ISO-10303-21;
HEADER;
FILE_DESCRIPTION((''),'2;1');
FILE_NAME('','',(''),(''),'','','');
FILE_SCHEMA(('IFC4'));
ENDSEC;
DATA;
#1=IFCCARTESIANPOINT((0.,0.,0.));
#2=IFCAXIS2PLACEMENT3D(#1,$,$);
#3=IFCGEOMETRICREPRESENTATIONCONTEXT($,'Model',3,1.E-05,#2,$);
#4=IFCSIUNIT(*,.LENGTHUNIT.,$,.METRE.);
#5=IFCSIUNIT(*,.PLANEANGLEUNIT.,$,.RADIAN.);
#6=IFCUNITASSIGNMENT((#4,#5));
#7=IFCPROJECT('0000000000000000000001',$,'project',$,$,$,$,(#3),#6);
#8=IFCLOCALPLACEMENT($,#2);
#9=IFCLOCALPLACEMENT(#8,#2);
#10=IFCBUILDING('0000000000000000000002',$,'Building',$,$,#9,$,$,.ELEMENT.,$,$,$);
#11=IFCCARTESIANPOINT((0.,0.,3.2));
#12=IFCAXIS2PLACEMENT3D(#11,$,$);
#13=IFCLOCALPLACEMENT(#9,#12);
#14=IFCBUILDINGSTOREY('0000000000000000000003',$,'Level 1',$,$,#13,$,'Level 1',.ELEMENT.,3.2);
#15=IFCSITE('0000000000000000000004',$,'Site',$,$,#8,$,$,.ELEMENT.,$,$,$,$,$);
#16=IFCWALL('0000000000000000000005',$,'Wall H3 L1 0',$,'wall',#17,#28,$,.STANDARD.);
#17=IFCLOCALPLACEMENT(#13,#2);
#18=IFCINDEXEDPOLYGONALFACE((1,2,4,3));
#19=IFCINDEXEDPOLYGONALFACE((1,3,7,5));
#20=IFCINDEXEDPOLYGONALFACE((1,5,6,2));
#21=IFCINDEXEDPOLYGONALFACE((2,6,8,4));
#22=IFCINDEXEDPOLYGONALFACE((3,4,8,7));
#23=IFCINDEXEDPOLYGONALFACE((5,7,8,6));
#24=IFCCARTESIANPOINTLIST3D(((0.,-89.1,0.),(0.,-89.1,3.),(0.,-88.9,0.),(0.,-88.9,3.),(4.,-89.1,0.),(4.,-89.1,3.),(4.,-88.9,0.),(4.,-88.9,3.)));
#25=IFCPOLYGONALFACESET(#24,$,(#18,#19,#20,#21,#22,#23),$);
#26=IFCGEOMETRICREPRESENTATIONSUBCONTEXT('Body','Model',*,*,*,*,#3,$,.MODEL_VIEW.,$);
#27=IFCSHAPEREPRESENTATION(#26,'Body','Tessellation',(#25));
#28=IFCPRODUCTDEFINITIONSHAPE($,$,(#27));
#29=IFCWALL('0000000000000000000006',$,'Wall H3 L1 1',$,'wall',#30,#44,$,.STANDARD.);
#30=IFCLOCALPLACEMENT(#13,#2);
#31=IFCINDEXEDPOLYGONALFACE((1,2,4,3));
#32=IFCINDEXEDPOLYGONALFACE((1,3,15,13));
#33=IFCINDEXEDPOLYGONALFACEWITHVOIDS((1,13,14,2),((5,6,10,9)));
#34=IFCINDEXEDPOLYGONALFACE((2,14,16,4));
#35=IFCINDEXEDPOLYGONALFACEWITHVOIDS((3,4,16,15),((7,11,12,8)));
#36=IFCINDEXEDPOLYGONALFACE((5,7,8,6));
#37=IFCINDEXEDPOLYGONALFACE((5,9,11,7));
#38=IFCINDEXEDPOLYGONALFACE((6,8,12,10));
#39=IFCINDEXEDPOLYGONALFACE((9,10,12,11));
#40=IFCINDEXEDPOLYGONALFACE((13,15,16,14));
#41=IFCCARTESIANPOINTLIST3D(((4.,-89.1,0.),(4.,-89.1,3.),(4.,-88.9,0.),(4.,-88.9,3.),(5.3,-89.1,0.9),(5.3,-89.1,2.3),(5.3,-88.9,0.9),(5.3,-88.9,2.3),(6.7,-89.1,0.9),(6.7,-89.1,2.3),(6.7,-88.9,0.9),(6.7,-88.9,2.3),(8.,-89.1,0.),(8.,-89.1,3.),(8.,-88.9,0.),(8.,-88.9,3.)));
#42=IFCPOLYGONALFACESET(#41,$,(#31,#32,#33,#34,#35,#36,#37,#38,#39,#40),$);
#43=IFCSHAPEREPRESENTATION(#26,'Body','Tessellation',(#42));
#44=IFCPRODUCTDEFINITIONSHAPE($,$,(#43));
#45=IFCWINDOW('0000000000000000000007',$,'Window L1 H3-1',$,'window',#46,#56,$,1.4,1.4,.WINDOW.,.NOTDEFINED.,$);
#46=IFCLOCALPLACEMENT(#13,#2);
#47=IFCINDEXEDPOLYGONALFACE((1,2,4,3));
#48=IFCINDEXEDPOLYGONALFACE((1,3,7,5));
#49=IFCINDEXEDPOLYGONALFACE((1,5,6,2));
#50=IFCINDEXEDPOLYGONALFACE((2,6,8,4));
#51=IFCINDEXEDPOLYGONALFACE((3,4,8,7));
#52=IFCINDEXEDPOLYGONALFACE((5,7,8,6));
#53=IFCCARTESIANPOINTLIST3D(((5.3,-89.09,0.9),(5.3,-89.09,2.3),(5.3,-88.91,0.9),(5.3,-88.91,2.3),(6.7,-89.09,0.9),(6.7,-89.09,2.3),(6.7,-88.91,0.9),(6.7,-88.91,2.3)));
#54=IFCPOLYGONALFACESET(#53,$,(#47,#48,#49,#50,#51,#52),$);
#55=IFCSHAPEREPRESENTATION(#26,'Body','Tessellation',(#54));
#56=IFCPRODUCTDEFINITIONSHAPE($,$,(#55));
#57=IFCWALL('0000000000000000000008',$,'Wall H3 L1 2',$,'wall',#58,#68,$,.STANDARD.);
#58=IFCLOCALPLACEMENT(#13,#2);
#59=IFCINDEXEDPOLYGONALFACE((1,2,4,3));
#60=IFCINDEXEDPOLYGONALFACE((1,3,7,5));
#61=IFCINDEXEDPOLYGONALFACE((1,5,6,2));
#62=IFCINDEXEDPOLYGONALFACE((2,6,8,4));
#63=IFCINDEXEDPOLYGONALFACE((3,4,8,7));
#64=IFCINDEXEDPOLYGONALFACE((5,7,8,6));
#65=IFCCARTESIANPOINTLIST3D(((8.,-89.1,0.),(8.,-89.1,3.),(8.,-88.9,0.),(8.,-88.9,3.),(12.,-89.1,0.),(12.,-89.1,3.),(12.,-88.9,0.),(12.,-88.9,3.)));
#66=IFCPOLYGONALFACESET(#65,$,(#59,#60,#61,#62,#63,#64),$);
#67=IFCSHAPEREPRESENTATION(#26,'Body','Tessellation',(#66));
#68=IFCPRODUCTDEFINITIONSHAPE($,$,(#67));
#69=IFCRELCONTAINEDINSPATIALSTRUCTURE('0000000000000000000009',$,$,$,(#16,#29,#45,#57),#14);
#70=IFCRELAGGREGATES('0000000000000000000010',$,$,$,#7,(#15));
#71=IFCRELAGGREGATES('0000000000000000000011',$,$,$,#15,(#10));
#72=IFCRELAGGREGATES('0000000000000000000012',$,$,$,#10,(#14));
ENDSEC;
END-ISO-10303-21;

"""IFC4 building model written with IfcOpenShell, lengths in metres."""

from ifc_helpers import new_model, si_unit, frame, frame_2d, origin, origin_2d, place, context, subcontext, project, spatial, rectangle, extrude, element, fill, save


model = new_model("IFC4")

# Units and contexts
model_context = context("Model", 3, precision=1e-05, world=origin())
body_context = subcontext(model_context, "Body", "Model", "MODEL_VIEW")
ifc_project = project(units=[si_unit("LENGTHUNIT", "METRE"), si_unit("PLANEANGLEUNIT", "RADIAN")], contexts=[model_context])

# Site, building, storey
site_placement = place(None, origin())
site = spatial("IfcSite", under=ifc_project, at=site_placement, Name="Site", CompositionType="ELEMENT")
building_placement = place(site_placement, origin())
building = spatial("IfcBuilding", under=site, at=building_placement, Name="Building", CompositionType="ELEMENT")
storey_placement = place(building_placement, frame((0.0, 0.0, 3.2)))
storey = spatial("IfcBuildingStorey", under=building, at=storey_placement, Name="Level 1", LongName="Level 1", CompositionType="ELEMENT", Elevation=3.2)

# Wall
for number, where, z_axis, x_axis, name in (
    (1, (0.0, -89.0, 0.0), (0.0, 0.0, 1.0), (1.0, 0.0, 0.0), "Wall H3 L1 0"),
):
    element("IfcWall", number, at=place(storey_placement, frame(where, z_axis=z_axis, x_axis=x_axis)), inside=storey, Name=name, ObjectType="wall", PredefinedType="STANDARD", context=body_context, shape_type="SweptSolid", body=[
        extrude(rectangle(XDim=4.0, YDim=0.2, at=frame_2d((2.0, 0.0))), origin(), (0.0, 0.0, 1.0), 3.0),
    ])

# Wall, opening, window
wall_1_placement = place(storey_placement, frame((4.0, -89.0, 0.0), z_axis=(0.0, 0.0, 1.0), x_axis=(1.0, 0.0, 0.0)))
wall_1 = element("IfcWall", 2, at=wall_1_placement, inside=storey, Name="Wall H3 L1 1", ObjectType="wall", PredefinedType="STANDARD", context=body_context, shape_type="SweptSolid", body=[
    extrude(rectangle(XDim=4.0, YDim=0.2, at=frame_2d((2.0, 0.0))), origin(), (0.0, 0.0, 1.0), 3.0),
])
opening_1_placement = place(storey_placement, frame((6.0, -89.0, 0.9), z_axis=(0.0, 0.0, 1.0), x_axis=(1.0, 0.0, 0.0)))
opening_1 = element("IfcOpeningElement", 3, at=opening_1_placement, cuts=wall_1, ObjectType="Opening", PredefinedType="OPENING", context=body_context, shape_type="SweptSolid", body=[
    extrude(rectangle(XDim=1.4, YDim=0.22, at=origin_2d()), origin(), (0.0, 0.0, 1.0), 1.4),
])
window_1_placement = place(storey_placement, frame((6.0, -89.0, 0.9), z_axis=(0.0, 0.0, 1.0), x_axis=(1.0, 0.0, 0.0)))
window_1 = element("IfcWindow", 4, at=window_1_placement, inside=storey, Name="Window L1 H3-1", ObjectType="window", OverallHeight=1.4, OverallWidth=1.4, PartitioningType="NOTDEFINED", PredefinedType="WINDOW", context=body_context, shape_type="SweptSolid", body=[
    extrude(rectangle(XDim=1.4, YDim=0.18, at=origin_2d()), origin(), (0.0, 0.0, 1.0), 1.4),
])
fill(opening_1, window_1)

# Wall
wall_2_placement = place(storey_placement, frame((8.0, -89.0, 0.0), z_axis=(0.0, 0.0, 1.0), x_axis=(1.0, 0.0, 0.0)))
element("IfcWall", 5, at=wall_2_placement, inside=storey, Name="Wall H3 L1 2", ObjectType="wall", PredefinedType="STANDARD", context=body_context, shape_type="SweptSolid", body=[
    extrude(rectangle(XDim=4.0, YDim=0.2, at=frame_2d((2.0, 0.0))), origin(), (0.0, 0.0, 1.0), 3.0),
])

save(model, "model.ifc")
